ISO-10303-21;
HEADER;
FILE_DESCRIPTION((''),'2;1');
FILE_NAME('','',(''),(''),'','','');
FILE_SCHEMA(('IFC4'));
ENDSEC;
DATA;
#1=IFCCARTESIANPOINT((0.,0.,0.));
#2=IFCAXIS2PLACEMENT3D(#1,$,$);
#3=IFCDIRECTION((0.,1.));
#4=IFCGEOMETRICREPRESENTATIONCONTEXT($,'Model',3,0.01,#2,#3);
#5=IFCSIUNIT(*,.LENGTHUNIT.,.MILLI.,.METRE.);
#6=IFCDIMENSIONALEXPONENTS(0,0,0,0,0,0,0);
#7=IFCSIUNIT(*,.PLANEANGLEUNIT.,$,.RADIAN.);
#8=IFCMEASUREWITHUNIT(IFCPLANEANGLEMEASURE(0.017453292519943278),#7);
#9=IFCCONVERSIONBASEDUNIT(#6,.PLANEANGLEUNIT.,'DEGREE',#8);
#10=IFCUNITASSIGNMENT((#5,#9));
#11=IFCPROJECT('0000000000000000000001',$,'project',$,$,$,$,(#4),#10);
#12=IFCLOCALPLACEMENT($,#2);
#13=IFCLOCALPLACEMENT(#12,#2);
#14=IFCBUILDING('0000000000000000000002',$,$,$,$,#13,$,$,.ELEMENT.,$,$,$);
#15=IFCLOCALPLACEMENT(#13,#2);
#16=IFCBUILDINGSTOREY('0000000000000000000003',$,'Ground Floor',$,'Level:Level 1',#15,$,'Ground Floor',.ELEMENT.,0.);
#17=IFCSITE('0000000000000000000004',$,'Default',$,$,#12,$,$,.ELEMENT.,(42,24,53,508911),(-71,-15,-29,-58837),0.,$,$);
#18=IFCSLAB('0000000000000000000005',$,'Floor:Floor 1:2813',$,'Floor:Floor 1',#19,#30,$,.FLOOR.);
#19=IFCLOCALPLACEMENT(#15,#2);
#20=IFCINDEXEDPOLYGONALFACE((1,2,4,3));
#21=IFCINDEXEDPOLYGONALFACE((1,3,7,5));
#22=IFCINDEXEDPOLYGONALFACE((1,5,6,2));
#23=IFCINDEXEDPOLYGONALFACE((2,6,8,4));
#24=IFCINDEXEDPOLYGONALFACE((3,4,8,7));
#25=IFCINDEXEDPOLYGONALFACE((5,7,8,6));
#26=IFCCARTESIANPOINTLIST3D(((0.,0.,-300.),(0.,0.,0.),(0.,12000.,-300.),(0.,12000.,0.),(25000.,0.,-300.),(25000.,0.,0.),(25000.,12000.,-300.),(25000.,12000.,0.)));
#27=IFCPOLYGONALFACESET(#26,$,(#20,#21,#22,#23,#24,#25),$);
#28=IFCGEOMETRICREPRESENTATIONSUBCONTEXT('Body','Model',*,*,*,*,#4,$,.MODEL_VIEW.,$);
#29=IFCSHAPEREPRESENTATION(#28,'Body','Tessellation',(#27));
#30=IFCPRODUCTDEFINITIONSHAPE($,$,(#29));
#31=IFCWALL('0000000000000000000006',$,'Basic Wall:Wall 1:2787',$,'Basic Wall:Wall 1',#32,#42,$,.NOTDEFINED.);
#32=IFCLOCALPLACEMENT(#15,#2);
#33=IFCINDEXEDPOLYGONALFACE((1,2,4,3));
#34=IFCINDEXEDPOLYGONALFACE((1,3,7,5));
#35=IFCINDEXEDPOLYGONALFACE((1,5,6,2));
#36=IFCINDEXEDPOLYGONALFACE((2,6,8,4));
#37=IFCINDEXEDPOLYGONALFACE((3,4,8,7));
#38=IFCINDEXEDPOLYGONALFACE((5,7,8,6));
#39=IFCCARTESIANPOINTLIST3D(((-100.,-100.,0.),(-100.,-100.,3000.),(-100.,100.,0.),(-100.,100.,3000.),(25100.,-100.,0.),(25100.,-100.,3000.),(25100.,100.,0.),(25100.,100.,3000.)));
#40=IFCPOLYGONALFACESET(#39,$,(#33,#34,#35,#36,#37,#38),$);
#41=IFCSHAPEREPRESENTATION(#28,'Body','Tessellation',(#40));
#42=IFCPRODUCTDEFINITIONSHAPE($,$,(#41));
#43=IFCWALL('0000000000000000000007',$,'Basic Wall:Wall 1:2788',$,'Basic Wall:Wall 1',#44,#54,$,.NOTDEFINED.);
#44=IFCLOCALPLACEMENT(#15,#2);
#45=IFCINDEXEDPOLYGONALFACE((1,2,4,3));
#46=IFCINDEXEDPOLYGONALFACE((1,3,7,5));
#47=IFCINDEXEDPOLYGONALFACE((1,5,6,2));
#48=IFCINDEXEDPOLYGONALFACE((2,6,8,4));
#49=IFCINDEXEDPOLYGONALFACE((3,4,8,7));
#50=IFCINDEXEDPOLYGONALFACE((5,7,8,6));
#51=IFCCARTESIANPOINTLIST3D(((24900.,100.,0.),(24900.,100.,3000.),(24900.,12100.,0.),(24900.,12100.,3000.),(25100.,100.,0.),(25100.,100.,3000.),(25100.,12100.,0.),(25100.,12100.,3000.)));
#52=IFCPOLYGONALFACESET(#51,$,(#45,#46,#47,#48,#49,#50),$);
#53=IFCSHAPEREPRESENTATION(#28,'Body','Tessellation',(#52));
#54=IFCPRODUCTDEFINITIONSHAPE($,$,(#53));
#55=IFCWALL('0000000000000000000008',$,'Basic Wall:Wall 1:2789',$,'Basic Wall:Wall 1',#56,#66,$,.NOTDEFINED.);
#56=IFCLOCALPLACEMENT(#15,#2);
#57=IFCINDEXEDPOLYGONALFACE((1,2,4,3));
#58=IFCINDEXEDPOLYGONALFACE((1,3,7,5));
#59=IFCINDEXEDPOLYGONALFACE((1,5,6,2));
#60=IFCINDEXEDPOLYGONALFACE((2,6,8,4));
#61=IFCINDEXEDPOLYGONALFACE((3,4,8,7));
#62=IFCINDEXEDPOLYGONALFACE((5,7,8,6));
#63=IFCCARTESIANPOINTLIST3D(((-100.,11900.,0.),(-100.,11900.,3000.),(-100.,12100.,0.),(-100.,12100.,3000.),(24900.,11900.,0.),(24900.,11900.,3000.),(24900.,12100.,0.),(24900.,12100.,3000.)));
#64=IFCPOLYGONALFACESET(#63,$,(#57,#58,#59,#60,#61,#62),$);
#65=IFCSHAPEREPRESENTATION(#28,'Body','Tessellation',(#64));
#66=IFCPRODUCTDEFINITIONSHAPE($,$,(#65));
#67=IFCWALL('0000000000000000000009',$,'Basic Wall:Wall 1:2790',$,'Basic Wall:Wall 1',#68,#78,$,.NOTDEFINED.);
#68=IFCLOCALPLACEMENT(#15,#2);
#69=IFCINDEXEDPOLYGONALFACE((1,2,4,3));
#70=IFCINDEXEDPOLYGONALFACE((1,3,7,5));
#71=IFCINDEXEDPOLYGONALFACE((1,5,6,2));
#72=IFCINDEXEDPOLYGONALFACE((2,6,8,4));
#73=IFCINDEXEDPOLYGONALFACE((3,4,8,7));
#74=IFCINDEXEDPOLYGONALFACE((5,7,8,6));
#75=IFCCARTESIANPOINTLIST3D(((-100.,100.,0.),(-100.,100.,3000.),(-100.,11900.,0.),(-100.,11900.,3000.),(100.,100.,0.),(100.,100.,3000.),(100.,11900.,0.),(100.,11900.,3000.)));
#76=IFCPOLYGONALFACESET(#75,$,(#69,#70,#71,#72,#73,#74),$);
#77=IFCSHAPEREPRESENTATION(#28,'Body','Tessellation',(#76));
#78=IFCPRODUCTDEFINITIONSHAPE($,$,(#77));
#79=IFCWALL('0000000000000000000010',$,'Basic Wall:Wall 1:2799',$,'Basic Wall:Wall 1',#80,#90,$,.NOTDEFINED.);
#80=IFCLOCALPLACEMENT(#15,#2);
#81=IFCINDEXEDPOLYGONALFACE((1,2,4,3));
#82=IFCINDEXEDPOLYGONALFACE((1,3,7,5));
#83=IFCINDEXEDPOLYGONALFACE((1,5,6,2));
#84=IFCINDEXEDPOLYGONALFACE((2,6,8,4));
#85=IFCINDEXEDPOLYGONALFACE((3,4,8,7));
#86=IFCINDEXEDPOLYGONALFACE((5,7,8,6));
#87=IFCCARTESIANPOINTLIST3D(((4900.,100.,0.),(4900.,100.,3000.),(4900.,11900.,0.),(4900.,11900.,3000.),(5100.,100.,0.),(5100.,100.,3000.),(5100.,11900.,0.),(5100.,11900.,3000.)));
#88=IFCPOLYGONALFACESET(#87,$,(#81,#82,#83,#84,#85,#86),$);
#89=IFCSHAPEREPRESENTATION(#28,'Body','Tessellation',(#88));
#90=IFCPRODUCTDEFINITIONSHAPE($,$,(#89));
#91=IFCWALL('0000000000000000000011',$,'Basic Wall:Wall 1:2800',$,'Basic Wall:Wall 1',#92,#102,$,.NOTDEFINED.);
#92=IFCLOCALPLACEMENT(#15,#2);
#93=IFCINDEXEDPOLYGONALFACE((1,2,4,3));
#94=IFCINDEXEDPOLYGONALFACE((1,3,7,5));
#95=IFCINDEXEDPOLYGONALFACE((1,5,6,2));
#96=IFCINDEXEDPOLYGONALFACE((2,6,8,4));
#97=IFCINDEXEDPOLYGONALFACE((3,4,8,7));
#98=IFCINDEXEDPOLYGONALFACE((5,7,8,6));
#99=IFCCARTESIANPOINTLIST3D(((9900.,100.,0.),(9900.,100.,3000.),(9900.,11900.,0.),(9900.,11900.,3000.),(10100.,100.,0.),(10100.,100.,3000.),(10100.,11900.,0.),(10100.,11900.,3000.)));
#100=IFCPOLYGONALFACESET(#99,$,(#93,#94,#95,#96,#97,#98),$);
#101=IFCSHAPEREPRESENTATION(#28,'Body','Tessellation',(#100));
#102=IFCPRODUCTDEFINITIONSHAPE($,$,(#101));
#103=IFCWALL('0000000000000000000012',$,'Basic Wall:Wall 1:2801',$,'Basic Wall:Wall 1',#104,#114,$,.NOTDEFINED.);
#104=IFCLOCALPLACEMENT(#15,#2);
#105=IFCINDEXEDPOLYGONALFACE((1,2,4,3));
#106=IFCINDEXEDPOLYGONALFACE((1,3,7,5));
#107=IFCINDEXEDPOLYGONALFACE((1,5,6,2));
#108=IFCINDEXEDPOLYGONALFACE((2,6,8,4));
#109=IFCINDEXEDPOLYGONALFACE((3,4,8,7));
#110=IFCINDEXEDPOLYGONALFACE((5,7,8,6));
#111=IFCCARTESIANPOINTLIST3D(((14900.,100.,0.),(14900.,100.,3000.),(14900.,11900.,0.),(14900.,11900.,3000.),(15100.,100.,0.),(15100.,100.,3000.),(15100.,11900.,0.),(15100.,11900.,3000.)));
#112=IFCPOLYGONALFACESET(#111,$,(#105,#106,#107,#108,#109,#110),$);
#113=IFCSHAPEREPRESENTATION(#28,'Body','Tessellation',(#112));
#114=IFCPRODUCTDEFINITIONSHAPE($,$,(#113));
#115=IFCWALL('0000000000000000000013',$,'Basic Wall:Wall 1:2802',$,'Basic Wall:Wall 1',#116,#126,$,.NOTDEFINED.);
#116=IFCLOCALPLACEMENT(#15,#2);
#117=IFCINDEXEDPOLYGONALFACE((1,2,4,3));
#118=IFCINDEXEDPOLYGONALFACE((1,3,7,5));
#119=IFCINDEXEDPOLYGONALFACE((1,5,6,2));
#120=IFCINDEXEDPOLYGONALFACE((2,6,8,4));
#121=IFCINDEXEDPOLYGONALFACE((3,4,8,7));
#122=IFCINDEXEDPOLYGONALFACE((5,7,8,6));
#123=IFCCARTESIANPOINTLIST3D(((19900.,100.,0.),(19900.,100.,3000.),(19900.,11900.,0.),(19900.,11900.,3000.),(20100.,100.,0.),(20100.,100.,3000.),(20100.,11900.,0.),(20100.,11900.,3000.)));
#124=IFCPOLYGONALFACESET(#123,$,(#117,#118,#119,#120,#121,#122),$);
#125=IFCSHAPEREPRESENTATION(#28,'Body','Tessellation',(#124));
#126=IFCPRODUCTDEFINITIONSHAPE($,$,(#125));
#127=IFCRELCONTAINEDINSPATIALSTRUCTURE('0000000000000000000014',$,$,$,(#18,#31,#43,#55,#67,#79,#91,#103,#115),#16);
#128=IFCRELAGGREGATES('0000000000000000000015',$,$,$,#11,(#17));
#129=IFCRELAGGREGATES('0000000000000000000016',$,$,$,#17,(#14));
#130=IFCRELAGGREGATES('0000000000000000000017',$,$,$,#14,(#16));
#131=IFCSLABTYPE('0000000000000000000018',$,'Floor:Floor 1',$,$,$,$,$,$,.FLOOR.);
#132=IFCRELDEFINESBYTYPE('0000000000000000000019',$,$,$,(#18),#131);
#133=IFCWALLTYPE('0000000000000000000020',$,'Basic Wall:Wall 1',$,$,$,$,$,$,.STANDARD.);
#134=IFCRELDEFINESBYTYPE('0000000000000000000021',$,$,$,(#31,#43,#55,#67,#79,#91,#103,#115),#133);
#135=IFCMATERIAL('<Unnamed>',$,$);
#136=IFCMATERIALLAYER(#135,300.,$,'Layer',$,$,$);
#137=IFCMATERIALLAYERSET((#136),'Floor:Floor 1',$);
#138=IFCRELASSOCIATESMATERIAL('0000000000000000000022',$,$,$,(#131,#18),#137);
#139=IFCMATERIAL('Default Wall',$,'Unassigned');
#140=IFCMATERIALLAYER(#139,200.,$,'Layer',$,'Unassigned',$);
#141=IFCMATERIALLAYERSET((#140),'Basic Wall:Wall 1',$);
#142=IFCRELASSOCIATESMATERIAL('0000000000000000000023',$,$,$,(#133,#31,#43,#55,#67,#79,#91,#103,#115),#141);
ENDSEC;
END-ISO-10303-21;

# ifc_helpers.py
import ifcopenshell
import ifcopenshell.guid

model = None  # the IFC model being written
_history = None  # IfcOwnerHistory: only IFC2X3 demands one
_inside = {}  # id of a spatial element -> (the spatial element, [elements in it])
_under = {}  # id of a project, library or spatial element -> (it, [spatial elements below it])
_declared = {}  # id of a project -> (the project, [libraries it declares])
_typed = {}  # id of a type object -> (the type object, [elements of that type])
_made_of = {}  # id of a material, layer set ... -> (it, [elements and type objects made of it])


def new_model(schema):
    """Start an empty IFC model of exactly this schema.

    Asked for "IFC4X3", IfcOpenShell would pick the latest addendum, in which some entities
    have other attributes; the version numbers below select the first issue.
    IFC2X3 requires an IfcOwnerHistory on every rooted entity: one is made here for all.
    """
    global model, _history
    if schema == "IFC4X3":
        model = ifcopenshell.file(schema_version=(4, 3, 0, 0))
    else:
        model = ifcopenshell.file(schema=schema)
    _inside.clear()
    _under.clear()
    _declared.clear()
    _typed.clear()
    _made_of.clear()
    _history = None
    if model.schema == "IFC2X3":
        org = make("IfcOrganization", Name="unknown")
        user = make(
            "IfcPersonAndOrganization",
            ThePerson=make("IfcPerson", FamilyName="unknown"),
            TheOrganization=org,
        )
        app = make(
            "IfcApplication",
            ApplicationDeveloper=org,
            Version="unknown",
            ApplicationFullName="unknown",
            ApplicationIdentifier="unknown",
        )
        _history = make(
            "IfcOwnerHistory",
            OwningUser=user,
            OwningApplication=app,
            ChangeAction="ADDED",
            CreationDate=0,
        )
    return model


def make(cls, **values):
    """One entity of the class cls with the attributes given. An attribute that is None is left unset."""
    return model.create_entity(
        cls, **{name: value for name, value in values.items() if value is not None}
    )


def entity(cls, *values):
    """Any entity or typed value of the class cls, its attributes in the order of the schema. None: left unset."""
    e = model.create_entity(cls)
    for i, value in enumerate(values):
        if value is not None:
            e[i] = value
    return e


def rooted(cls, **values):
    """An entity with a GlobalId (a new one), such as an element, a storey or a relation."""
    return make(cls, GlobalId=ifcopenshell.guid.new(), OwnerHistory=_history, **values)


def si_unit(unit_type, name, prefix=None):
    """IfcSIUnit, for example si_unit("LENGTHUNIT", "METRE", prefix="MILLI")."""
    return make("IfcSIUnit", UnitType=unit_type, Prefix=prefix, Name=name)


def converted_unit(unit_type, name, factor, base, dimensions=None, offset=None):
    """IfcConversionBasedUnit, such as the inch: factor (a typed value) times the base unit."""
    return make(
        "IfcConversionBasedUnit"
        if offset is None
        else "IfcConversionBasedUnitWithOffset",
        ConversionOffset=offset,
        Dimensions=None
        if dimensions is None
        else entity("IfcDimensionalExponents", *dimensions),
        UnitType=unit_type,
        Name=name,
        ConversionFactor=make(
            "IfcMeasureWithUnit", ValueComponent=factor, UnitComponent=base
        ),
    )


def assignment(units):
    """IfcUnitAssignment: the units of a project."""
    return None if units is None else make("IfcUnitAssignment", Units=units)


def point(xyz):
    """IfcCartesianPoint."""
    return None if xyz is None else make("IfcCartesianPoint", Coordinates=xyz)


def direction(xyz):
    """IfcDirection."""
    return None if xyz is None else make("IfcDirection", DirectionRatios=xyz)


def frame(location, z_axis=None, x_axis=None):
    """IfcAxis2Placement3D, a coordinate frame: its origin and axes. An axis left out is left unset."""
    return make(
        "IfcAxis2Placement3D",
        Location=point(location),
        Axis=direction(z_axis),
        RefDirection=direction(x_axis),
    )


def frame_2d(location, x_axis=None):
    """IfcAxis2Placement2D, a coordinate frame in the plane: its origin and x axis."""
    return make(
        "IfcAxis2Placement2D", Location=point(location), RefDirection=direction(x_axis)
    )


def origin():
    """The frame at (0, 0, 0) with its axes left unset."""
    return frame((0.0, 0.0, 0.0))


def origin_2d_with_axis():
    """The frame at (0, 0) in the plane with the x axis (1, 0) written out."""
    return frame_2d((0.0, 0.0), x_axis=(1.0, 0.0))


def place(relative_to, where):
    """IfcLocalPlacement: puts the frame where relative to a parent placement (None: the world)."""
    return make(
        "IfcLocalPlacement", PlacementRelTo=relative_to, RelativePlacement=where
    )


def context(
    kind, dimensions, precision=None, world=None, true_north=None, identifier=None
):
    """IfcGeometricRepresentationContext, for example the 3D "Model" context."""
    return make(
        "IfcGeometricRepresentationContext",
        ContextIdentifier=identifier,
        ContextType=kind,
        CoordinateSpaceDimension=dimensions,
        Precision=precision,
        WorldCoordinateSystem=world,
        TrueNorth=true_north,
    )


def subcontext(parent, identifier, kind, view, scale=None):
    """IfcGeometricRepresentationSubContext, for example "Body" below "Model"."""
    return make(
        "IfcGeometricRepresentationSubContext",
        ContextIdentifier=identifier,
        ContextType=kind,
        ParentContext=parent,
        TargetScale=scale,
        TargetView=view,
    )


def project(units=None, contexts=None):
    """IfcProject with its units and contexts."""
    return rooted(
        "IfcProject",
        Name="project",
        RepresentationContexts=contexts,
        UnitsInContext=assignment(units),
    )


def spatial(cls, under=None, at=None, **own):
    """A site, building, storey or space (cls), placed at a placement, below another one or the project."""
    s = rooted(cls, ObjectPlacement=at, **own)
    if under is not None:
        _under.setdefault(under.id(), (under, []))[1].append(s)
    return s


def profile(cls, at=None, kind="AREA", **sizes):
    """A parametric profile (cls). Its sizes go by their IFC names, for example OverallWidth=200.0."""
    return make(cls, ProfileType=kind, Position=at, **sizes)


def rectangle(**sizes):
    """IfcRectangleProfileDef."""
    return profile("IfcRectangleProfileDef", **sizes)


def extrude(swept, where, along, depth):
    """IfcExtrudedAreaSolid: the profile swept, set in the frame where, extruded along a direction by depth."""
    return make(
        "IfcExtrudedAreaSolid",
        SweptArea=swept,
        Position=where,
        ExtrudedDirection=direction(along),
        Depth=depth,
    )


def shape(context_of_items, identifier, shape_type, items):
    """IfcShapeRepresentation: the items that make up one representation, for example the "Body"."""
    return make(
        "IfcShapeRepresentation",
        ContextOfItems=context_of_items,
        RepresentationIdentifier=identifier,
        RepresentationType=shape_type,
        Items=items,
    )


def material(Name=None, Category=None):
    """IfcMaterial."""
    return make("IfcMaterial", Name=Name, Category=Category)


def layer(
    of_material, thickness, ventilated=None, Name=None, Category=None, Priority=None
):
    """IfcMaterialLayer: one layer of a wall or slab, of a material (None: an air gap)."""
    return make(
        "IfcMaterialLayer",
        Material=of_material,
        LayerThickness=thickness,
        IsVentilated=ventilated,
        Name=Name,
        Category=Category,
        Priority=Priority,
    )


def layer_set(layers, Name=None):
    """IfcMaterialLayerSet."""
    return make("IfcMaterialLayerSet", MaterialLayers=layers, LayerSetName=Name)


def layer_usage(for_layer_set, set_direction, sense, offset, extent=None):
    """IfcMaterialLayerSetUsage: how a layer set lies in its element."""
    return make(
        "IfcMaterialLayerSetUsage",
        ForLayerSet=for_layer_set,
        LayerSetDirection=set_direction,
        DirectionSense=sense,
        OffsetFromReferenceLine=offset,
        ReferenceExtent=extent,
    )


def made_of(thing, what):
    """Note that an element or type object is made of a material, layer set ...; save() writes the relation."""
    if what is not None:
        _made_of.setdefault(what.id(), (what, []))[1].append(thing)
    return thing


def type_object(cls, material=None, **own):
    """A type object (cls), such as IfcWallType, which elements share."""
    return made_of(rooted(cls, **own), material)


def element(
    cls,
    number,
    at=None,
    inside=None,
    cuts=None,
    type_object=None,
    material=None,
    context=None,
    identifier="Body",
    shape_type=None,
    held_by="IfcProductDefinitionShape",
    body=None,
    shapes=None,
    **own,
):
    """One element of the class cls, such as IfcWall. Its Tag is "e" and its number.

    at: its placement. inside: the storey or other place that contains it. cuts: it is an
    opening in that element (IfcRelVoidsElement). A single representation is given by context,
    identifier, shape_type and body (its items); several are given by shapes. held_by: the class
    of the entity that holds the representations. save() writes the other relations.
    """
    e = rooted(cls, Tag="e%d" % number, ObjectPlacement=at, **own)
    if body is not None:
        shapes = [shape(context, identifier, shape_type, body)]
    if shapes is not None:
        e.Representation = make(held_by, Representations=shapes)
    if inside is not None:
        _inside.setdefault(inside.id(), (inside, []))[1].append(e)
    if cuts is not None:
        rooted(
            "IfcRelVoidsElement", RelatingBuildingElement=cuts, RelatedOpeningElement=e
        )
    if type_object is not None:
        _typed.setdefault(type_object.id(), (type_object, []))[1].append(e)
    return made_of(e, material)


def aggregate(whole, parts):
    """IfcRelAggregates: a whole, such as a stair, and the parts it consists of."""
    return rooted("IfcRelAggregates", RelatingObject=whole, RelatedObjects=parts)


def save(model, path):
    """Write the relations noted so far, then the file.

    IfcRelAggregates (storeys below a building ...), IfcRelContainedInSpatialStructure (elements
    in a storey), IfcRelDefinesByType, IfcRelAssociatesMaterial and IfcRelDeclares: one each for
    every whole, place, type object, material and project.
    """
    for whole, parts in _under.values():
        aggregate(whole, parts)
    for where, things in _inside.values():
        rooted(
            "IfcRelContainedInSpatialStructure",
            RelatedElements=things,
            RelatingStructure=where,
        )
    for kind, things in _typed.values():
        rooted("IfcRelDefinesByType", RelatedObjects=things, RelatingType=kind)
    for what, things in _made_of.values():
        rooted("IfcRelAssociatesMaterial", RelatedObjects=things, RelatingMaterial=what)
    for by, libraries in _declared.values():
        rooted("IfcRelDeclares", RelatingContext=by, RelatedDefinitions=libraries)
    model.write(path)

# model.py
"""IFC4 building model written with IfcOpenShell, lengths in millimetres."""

from ifc_helpers import new_model, entity, si_unit, converted_unit, direction, frame, frame_2d, origin, origin_2d_with_axis, place, context, subcontext, project, spatial, rectangle, extrude, material, layer, layer_set, layer_usage, type_object, element, save


model = new_model("IFC4")

# Units and contexts
model_context = context("Model", 3, precision=0.01, world=origin(), true_north=direction((0.0, 1.0)))
body_context = subcontext(model_context, "Body", "Model", "MODEL_VIEW")
ifc_project = project(units=[si_unit("LENGTHUNIT", "METRE", prefix="MILLI"), converted_unit("PLANEANGLEUNIT", "DEGREE", entity("IfcPlaneAngleMeasure", 0.017453292519943278), si_unit("PLANEANGLEUNIT", "RADIAN"), dimensions=[0, 0, 0, 0, 0, 0, 0])], contexts=[model_context])

# Site, building, storey
site_placement = place(None, origin())
site = spatial("IfcSite", under=ifc_project, at=site_placement, Name="Default", CompositionType="ELEMENT", RefLatitude=(42, 24, 53, 508911), RefLongitude=(-71, -15, -29, -58837), RefElevation=0.0)
building_placement = place(site_placement, origin())
building = spatial("IfcBuilding", under=site, at=building_placement, CompositionType="ELEMENT")
storey_placement = place(building_placement, origin())
storey = spatial("IfcBuildingStorey", under=building, at=storey_placement, Name="Ground Floor", ObjectType="Level:Level 1", LongName="Ground Floor", CompositionType="ELEMENT", Elevation=0.0)

# Shared definitions
ifc_material_1 = material(Name="Default Wall", Category="Unassigned")

# Slab
ifc_material_2 = material(Name="<Unnamed>")
ifc_layer_1 = layer(ifc_material_2, 300.0, Name="Layer")
ifc_layer_set_1 = layer_set([ifc_layer_1], Name="Floor:Floor 1")
ifc_layer_usage_1 = layer_usage(ifc_layer_set_1, "AXIS3", "POSITIVE", 0.0)
slab_type = type_object("IfcSlabType", Name="Floor:Floor 1", PredefinedType="FLOOR", material=ifc_layer_set_1)
slab_placement = place(storey_placement, origin())
element("IfcSlab", 1, at=slab_placement, inside=storey, type_object=slab_type, material=ifc_layer_usage_1, Name="Floor:Floor 1:2813", ObjectType="Floor:Floor 1", PredefinedType="FLOOR", context=body_context, shape_type="SweptSolid", body=[
    extrude(rectangle(XDim=12000.0, YDim=25000.0, at=origin_2d_with_axis()), frame((12500.0, 6000.0, 0.0), z_axis=(0.0, 0.0, -1.0), x_axis=(0.0, 1.0, 0.0)), (0.0, 0.0, 1.0), 300.0),
])

# Walls
ifc_layer_2 = layer(ifc_material_1, 200.0, Name="Layer", Category="Unassigned")
ifc_layer_set_2 = layer_set([ifc_layer_2], Name="Basic Wall:Wall 1")
ifc_layer_usage_2 = layer_usage(ifc_layer_set_2, "AXIS2", "NEGATIVE", 100.0)
wall_type = type_object("IfcWallType", Name="Basic Wall:Wall 1", PredefinedType="STANDARD", material=ifc_layer_set_2)
wall_1_placement = place(storey_placement, frame((-100.0, 0.0, 0.0)))
element("IfcWall", 2, at=wall_1_placement, inside=storey, type_object=wall_type, material=ifc_layer_usage_2, Name="Basic Wall:Wall 1:2787", ObjectType="Basic Wall:Wall 1", PredefinedType="NOTDEFINED", context=body_context, shape_type="SweptSolid", body=[
    extrude(rectangle(XDim=25200.0, YDim=200.0, at=frame_2d((12600.0, 0.0), x_axis=(-1.0, 0.0))), origin(), (0.0, 0.0, 1.0), 3000.0),
])
ifc_layer_usage_3 = layer_usage(ifc_layer_set_2, "AXIS2", "NEGATIVE", 100.0)
wall_2_placement = place(storey_placement, frame((25000.0, 100.0, 0.0), z_axis=(0.0, 0.0, 1.0), x_axis=(0.0, 1.0, 0.0)))
element("IfcWall", 3, at=wall_2_placement, inside=storey, type_object=wall_type, material=ifc_layer_usage_3, Name="Basic Wall:Wall 1:2788", ObjectType="Basic Wall:Wall 1", PredefinedType="NOTDEFINED", context=body_context, shape_type="SweptSolid", body=[
    extrude(rectangle(XDim=12000.0, YDim=200.0, at=frame_2d((6000.0, 0.0), x_axis=(-1.0, 0.0))), origin(), (0.0, 0.0, 1.0), 3000.0),
])
ifc_layer_usage_4 = layer_usage(ifc_layer_set_2, "AXIS2", "NEGATIVE", 100.0)
wall_3_placement = place(storey_placement, frame((24900.0, 12000.0, 0.0), z_axis=(0.0, 0.0, 1.0), x_axis=(-1.0, 0.0, 0.0)))
element("IfcWall", 4, at=wall_3_placement, inside=storey, type_object=wall_type, material=ifc_layer_usage_4, Name="Basic Wall:Wall 1:2789", ObjectType="Basic Wall:Wall 1", PredefinedType="NOTDEFINED", context=body_context, shape_type="SweptSolid", body=[
    extrude(rectangle(XDim=25000.0, YDim=200.0, at=frame_2d((12500.0, 0.0), x_axis=(-1.0, 0.0))), origin(), (0.0, 0.0, 1.0), 3000.0),
])
ifc_layer_usage_5 = layer_usage(ifc_layer_set_2, "AXIS2", "NEGATIVE", 100.0)
wall_4_placement = place(storey_placement, frame((0.0, 11900.0, 0.0), z_axis=(0.0, 0.0, 1.0), x_axis=(0.0, -1.0, 0.0)))
element("IfcWall", 5, at=wall_4_placement, inside=storey, type_object=wall_type, material=ifc_layer_usage_5, Name="Basic Wall:Wall 1:2790", ObjectType="Basic Wall:Wall 1", PredefinedType="NOTDEFINED", context=body_context, shape_type="SweptSolid", body=[
    extrude(rectangle(XDim=11800.0, YDim=200.0, at=frame_2d((5900.0, 0.0), x_axis=(-1.0, 0.0))), origin(), (0.0, 0.0, 1.0), 3000.0),
])
ifc_layer_usage_6 = layer_usage(ifc_layer_set_2, "AXIS2", "NEGATIVE", 100.0)
wall_5_placement = place(storey_placement, frame((5000.0, 100.0, 0.0), z_axis=(0.0, 0.0, 1.0), x_axis=(0.0, 1.0, 0.0)))
element("IfcWall", 6, at=wall_5_placement, inside=storey, type_object=wall_type, material=ifc_layer_usage_6, Name="Basic Wall:Wall 1:2799", ObjectType="Basic Wall:Wall 1", PredefinedType="NOTDEFINED", context=body_context, shape_type="SweptSolid", body=[
    extrude(rectangle(XDim=11800.0, YDim=200.0, at=frame_2d((5900.0, 0.0), x_axis=(-1.0, 0.0))), origin(), (0.0, 0.0, 1.0), 3000.0),
])
ifc_layer_usage_7 = layer_usage(ifc_layer_set_2, "AXIS2", "NEGATIVE", 100.0)
wall_6_placement = place(storey_placement, frame((10000.0, 100.0, 0.0), z_axis=(0.0, 0.0, 1.0), x_axis=(0.0, 1.0, 0.0)))
element("IfcWall", 7, at=wall_6_placement, inside=storey, type_object=wall_type, material=ifc_layer_usage_7, Name="Basic Wall:Wall 1:2800", ObjectType="Basic Wall:Wall 1", PredefinedType="NOTDEFINED", context=body_context, shape_type="SweptSolid", body=[
    extrude(rectangle(XDim=11800.0, YDim=200.0, at=frame_2d((5900.0, 0.0), x_axis=(-1.0, 0.0))), origin(), (0.0, 0.0, 1.0), 3000.0),
])
ifc_layer_usage_8 = layer_usage(ifc_layer_set_2, "AXIS2", "NEGATIVE", 100.0)
wall_7_placement = place(storey_placement, frame((15000.0, 100.0, 0.0), z_axis=(0.0, 0.0, 1.0), x_axis=(0.0, 1.0, 0.0)))
element("IfcWall", 8, at=wall_7_placement, inside=storey, type_object=wall_type, material=ifc_layer_usage_8, Name="Basic Wall:Wall 1:2801", ObjectType="Basic Wall:Wall 1", PredefinedType="NOTDEFINED", context=body_context, shape_type="SweptSolid", body=[
    extrude(rectangle(XDim=11800.0, YDim=200.0, at=frame_2d((5900.0, 0.0), x_axis=(-1.0, 0.0))), origin(), (0.0, 0.0, 1.0), 3000.0),
])
ifc_layer_usage_9 = layer_usage(ifc_layer_set_2, "AXIS2", "NEGATIVE", 100.0)
wall_8_placement = place(storey_placement, frame((20000.0, 100.0, 0.0), z_axis=(0.0, 0.0, 1.0), x_axis=(0.0, 1.0, 0.0)))
element("IfcWall", 9, at=wall_8_placement, inside=storey, type_object=wall_type, material=ifc_layer_usage_9, Name="Basic Wall:Wall 1:2802", ObjectType="Basic Wall:Wall 1", PredefinedType="NOTDEFINED", context=body_context, shape_type="SweptSolid", body=[
    extrude(rectangle(XDim=11800.0, YDim=200.0, at=frame_2d((5900.0, 0.0), x_axis=(-1.0, 0.0))), origin(), (0.0, 0.0, 1.0), 3000.0),
])

save(model, "model.ifc")
